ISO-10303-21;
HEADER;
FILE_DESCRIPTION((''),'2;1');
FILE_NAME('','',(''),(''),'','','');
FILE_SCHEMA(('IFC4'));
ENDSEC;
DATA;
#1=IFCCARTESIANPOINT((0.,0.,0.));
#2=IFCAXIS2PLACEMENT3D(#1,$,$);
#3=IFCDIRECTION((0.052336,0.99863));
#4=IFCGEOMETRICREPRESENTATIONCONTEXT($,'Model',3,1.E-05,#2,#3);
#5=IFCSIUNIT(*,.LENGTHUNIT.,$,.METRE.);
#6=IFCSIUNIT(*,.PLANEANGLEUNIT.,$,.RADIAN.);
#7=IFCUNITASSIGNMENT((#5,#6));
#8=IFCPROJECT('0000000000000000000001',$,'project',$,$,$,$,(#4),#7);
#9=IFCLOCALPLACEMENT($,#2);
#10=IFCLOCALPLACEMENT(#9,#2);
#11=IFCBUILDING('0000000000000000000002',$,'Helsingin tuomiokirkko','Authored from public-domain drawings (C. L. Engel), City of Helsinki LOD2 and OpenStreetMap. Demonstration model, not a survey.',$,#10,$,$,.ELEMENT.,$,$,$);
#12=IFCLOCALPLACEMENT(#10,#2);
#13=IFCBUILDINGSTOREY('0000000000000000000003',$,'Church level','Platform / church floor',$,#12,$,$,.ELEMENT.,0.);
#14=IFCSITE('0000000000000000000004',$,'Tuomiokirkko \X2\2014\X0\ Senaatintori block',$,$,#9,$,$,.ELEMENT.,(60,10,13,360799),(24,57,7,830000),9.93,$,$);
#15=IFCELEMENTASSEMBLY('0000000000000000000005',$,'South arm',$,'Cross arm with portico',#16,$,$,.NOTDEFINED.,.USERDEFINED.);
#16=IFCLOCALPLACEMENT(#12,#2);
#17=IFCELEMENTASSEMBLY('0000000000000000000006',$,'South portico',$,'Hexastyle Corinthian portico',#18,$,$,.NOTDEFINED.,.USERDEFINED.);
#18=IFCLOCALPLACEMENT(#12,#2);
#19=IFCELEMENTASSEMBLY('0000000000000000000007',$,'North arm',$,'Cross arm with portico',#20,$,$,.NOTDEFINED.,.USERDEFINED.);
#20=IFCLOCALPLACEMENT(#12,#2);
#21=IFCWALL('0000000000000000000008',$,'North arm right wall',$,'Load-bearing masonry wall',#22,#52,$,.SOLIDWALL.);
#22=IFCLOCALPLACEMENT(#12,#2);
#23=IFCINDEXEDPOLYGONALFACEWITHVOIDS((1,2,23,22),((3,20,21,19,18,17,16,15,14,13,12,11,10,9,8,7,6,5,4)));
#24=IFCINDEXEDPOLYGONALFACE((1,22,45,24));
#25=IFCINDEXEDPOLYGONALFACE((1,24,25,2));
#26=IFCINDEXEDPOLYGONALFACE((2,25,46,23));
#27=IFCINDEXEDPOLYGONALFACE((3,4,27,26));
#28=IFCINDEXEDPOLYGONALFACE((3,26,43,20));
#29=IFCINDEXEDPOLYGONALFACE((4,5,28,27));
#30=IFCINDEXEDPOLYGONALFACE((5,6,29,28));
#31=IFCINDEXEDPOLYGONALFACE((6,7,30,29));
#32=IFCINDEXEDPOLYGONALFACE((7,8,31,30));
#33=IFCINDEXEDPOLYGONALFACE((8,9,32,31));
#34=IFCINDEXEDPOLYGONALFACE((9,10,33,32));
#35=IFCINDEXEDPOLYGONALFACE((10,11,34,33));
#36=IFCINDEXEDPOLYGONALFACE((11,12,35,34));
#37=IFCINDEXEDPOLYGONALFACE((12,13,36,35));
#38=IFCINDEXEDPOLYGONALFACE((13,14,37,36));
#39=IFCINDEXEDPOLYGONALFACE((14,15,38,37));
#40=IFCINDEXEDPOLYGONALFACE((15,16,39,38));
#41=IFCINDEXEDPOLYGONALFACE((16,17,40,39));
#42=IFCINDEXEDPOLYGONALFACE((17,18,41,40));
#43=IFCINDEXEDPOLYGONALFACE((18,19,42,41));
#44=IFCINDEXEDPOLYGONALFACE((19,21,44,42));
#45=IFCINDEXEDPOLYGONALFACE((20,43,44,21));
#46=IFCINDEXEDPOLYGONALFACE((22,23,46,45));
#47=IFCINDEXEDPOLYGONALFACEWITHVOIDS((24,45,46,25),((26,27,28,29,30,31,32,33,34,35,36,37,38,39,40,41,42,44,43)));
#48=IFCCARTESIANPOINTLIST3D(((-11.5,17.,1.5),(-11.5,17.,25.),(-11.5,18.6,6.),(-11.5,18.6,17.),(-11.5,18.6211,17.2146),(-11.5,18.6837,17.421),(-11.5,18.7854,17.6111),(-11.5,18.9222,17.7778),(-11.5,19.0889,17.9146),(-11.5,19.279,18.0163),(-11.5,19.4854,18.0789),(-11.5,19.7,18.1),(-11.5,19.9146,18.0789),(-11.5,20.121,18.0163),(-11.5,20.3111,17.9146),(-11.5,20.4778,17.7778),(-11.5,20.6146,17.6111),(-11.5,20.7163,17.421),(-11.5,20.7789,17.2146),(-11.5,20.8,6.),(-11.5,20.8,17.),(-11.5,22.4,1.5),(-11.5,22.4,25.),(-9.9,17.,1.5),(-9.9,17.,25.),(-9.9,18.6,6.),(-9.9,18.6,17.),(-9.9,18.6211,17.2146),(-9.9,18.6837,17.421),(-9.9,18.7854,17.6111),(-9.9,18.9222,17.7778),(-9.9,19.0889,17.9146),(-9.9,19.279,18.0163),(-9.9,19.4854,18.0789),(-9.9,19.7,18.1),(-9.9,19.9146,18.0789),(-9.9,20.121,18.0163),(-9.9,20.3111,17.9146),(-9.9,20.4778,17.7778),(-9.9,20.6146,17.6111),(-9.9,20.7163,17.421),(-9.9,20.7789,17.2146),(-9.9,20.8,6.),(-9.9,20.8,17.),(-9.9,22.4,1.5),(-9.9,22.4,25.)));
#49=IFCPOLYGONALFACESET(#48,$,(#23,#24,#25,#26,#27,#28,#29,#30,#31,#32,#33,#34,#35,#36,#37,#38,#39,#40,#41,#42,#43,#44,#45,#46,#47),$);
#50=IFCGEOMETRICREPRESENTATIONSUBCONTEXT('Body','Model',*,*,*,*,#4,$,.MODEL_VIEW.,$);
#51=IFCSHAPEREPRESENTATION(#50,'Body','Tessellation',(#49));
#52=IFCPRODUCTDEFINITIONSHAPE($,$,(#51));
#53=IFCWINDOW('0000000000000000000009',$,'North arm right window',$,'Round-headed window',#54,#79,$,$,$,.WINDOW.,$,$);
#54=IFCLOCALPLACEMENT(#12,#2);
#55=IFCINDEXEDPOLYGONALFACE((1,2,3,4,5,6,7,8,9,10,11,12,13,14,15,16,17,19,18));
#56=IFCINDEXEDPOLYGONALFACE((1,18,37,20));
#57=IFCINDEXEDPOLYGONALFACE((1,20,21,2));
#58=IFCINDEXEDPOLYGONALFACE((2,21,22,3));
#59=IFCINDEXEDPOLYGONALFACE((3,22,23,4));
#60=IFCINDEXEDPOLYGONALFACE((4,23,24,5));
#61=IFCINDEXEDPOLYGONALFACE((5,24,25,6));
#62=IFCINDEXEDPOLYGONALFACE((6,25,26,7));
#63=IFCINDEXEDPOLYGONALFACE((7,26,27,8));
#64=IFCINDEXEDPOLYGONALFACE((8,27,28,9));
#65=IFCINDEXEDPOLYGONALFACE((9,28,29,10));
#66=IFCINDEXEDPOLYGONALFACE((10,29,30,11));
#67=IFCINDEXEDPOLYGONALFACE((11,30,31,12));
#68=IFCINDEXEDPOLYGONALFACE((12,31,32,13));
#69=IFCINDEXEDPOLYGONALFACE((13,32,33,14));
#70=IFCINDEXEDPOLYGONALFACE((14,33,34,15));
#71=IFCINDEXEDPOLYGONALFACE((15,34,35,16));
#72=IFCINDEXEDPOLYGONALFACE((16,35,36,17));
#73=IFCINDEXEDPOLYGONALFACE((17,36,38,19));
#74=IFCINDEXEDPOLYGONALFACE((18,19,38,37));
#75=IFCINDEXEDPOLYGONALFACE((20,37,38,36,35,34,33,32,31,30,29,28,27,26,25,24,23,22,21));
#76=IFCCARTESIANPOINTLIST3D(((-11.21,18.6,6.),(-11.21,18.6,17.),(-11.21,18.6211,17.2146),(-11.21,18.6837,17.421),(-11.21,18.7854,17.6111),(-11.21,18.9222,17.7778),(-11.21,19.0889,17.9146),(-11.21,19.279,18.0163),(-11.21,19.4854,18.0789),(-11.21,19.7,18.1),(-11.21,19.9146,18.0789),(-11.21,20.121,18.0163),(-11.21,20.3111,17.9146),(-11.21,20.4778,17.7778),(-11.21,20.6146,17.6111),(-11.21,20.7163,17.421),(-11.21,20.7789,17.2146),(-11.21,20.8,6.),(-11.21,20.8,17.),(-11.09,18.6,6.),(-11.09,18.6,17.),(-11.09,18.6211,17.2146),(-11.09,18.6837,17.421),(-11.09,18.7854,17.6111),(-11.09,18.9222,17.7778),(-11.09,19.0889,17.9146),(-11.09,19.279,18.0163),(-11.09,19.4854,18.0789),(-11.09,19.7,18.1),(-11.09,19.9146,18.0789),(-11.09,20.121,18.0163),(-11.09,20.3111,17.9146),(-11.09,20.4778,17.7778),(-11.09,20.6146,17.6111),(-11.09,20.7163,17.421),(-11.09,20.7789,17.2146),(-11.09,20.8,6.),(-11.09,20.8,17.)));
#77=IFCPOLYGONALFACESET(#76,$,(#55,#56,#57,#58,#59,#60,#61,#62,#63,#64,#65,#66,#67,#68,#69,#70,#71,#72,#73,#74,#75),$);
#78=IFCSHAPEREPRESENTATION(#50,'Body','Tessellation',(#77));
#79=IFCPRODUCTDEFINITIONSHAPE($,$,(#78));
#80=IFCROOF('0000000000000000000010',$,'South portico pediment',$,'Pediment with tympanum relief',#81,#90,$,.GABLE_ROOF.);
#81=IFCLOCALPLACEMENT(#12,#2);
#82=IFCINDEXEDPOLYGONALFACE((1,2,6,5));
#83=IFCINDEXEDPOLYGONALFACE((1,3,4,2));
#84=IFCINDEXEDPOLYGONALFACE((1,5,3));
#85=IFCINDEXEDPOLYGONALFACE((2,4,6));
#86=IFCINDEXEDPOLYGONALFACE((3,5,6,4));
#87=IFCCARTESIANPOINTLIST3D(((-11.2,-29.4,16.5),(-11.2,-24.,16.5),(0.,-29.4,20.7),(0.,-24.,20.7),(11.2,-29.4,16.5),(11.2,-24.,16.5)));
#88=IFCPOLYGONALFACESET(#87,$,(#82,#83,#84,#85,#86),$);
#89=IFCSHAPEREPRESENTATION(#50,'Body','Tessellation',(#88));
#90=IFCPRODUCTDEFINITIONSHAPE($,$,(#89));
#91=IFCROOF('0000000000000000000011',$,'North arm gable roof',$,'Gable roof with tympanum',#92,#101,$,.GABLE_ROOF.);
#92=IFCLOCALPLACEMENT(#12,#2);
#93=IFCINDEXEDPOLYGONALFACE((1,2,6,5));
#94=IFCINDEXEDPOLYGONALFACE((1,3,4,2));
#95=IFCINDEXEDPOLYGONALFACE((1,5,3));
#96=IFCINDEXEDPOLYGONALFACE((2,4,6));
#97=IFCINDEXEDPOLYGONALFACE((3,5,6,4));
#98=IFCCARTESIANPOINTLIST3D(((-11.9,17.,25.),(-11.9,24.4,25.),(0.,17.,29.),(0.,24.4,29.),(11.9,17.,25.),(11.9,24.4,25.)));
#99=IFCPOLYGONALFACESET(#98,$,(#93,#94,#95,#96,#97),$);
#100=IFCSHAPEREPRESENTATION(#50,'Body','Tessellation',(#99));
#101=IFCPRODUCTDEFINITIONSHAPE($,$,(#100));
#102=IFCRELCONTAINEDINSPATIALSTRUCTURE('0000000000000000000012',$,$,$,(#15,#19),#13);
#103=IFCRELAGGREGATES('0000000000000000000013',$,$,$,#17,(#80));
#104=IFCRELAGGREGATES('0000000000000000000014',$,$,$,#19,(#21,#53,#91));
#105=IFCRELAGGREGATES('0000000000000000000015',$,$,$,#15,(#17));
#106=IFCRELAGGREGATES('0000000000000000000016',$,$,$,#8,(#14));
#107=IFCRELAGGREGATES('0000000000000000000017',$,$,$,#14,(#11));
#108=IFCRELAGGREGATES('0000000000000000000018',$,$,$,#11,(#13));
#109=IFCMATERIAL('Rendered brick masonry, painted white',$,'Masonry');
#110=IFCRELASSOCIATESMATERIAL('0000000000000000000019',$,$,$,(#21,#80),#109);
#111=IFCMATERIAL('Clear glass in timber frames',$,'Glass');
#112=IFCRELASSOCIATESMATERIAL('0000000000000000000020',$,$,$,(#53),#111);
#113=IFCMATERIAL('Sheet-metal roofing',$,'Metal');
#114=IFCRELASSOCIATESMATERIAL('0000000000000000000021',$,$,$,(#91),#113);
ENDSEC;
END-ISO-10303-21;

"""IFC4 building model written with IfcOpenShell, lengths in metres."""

from ifc_helpers import new_model, si_unit, direction, frame, frame_2d, origin, place, context, subcontext, project, spatial, polyline, rectangle, outline, extrude, material, element, fill, aggregate, save


model = new_model("IFC4")

# Units and contexts
model_context = context("Model", 3, precision=1e-05, world=origin(), true_north=direction((0.052336, 0.99863)))
body_context = subcontext(model_context, "Body", "Model", "MODEL_VIEW")
ifc_project = project(units=[si_unit("LENGTHUNIT", "METRE"), si_unit("PLANEANGLEUNIT", "RADIAN")], contexts=[model_context])

# Site, building, storey
site_placement = place(None, origin())
site = spatial("IfcSite", under=ifc_project, at=site_placement, Name="Tuomiokirkko — Senaatintori block", CompositionType="ELEMENT", RefLatitude=(60, 10, 13, 360799), RefLongitude=(24, 57, 7, 830000), RefElevation=9.93)
building_placement = place(site_placement, origin())
building = spatial("IfcBuilding", under=site, at=building_placement, Name="Helsingin tuomiokirkko", Description="Authored from public-domain drawings (C. L. Engel), City of Helsinki LOD2 and OpenStreetMap. Demonstration model, not a survey.", CompositionType="ELEMENT")
storey_placement = place(building_placement, origin())
storey = spatial("IfcBuildingStorey", under=building, at=storey_placement, Name="Church level", Description="Platform / church floor", CompositionType="ELEMENT", Elevation=0.0)

# Element assemblies
assembly_1_placement = place(building_placement, origin())
assembly_1 = element("IfcElementAssembly", 1, at=assembly_1_placement, inside=storey, Name="South arm", ObjectType="Cross arm with portico", AssemblyPlace="NOTDEFINED", PredefinedType="USERDEFINED")
assembly_2_placement = place(building_placement, origin())
assembly_2 = element("IfcElementAssembly", 2, at=assembly_2_placement, Name="South portico", ObjectType="Hexastyle Corinthian portico", AssemblyPlace="NOTDEFINED", PredefinedType="USERDEFINED")
assembly_3_placement = place(building_placement, origin())
assembly_3 = element("IfcElementAssembly", 3, at=assembly_3_placement, inside=storey, Name="North arm", ObjectType="Cross arm with portico", AssemblyPlace="NOTDEFINED", PredefinedType="USERDEFINED")
ifc_material_1 = material(Name="Rendered brick masonry, painted white", Category="Masonry")

# Shared definitions
ifc_material_2 = material(Name="Clear glass in timber frames", Category="Glass")

# Wall, opening, window
wall_1_placement = place(building_placement, origin())
wall_1 = element("IfcWall", 4, at=wall_1_placement, material=ifc_material_1, Name="North arm right wall", ObjectType="Load-bearing masonry wall", PredefinedType="SOLIDWALL", context=body_context, shape_type="SweptSolid", body=[
    extrude(rectangle(XDim=5.4, YDim=1.6, at=frame_2d((0.0, 0.0), x_axis=(0.0, 1.0))), frame((-10.7, 19.7, 1.5)), (0.0, 0.0, 1.0), 23.5),
])
opening_1_placement = place(building_placement, origin())
opening_1 = element("IfcOpeningElement", 5, at=opening_1_placement, cuts=wall_1, PredefinedType="OPENING", context=body_context, shape_type="SweptSolid", body=[
    extrude(outline(polyline([(-1.1, 0.0), (1.1, 0.0), (1.1, 11.0), (1.0789, 11.2146), (1.0163, 11.421), (0.9146, 11.6111), (0.7778, 11.7778), (0.6111, 11.9146), (0.421, 12.0163), (0.2146, 12.0789), (0.0, 12.1), (-0.2146, 12.0789), (-0.421, 12.0163), (-0.6111, 11.9146), (-0.7778, 11.7778), (-0.9146, 11.6111), (-1.0163, 11.421), (-1.0789, 11.2146), (-1.1, 11.0), (-1.1, 0.0)])), frame((-11.7, 19.7, 6.0), z_axis=(1.0, 0.0, 0.0), x_axis=(0.0, 1.0, 0.0)), (0.0, 0.0, 1.0), 2.0),
])
window_1_placement = place(building_placement, origin())
window_1 = element("IfcWindow", 6, at=window_1_placement, material=ifc_material_2, Name="North arm right window", ObjectType="Round-headed window", PredefinedType="WINDOW", context=body_context, shape_type="SweptSolid", body=[
    extrude(outline(polyline([(-1.1, 0.0), (1.1, 0.0), (1.1, 11.0), (1.0789, 11.2146), (1.0163, 11.421), (0.9146, 11.6111), (0.7778, 11.7778), (0.6111, 11.9146), (0.421, 12.0163), (0.2146, 12.0789), (0.0, 12.1), (-0.2146, 12.0789), (-0.421, 12.0163), (-0.6111, 11.9146), (-0.7778, 11.7778), (-0.9146, 11.6111), (-1.0163, 11.421), (-1.0789, 11.2146), (-1.1, 11.0), (-1.1, 0.0)])), frame((-11.21, 19.7, 6.0), z_axis=(1.0, 0.0, 0.0), x_axis=(0.0, 1.0, 0.0)), (0.0, 0.0, 1.0), 0.12),
])
fill(opening_1, window_1)

# Roofs
roof_1_placement = place(building_placement, origin())
roof_1 = element("IfcRoof", 7, at=roof_1_placement, material=ifc_material_1, Name="South portico pediment", ObjectType="Pediment with tympanum relief", PredefinedType="GABLE_ROOF", context=body_context, shape_type="SweptSolid", body=[
    extrude(outline(polyline([(-11.2, 0.0), (11.2, 0.0), (0.0, 4.2), (-11.2, 0.0)])), frame((0.0, -24.0, 16.5), z_axis=(0.0, -1.0, 0.0), x_axis=(1.0, 0.0, 0.0)), (0.0, 0.0, 1.0), 5.4),
])
aggregate(assembly_2, [roof_1])
ifc_material_3 = material(Name="Sheet-metal roofing", Category="Metal")
roof_2_placement = place(building_placement, origin())
roof_2 = element("IfcRoof", 8, at=roof_2_placement, material=ifc_material_3, Name="North arm gable roof", ObjectType="Gable roof with tympanum", PredefinedType="GABLE_ROOF", context=body_context, shape_type="SweptSolid", body=[
    extrude(outline(polyline([(-11.9, 0.0), (11.9, 0.0), (0.0, 4.0), (-11.9, 0.0)])), frame((0.0, 17.0, 25.0), z_axis=(0.0, 1.0, 0.0), x_axis=(-1.0, 0.0, 0.0)), (0.0, 0.0, 1.0), 7.4),
])
aggregate(assembly_3, [wall_1, window_1, roof_2])

aggregate(assembly_1, [assembly_2])

save(model, "model.ifc")
